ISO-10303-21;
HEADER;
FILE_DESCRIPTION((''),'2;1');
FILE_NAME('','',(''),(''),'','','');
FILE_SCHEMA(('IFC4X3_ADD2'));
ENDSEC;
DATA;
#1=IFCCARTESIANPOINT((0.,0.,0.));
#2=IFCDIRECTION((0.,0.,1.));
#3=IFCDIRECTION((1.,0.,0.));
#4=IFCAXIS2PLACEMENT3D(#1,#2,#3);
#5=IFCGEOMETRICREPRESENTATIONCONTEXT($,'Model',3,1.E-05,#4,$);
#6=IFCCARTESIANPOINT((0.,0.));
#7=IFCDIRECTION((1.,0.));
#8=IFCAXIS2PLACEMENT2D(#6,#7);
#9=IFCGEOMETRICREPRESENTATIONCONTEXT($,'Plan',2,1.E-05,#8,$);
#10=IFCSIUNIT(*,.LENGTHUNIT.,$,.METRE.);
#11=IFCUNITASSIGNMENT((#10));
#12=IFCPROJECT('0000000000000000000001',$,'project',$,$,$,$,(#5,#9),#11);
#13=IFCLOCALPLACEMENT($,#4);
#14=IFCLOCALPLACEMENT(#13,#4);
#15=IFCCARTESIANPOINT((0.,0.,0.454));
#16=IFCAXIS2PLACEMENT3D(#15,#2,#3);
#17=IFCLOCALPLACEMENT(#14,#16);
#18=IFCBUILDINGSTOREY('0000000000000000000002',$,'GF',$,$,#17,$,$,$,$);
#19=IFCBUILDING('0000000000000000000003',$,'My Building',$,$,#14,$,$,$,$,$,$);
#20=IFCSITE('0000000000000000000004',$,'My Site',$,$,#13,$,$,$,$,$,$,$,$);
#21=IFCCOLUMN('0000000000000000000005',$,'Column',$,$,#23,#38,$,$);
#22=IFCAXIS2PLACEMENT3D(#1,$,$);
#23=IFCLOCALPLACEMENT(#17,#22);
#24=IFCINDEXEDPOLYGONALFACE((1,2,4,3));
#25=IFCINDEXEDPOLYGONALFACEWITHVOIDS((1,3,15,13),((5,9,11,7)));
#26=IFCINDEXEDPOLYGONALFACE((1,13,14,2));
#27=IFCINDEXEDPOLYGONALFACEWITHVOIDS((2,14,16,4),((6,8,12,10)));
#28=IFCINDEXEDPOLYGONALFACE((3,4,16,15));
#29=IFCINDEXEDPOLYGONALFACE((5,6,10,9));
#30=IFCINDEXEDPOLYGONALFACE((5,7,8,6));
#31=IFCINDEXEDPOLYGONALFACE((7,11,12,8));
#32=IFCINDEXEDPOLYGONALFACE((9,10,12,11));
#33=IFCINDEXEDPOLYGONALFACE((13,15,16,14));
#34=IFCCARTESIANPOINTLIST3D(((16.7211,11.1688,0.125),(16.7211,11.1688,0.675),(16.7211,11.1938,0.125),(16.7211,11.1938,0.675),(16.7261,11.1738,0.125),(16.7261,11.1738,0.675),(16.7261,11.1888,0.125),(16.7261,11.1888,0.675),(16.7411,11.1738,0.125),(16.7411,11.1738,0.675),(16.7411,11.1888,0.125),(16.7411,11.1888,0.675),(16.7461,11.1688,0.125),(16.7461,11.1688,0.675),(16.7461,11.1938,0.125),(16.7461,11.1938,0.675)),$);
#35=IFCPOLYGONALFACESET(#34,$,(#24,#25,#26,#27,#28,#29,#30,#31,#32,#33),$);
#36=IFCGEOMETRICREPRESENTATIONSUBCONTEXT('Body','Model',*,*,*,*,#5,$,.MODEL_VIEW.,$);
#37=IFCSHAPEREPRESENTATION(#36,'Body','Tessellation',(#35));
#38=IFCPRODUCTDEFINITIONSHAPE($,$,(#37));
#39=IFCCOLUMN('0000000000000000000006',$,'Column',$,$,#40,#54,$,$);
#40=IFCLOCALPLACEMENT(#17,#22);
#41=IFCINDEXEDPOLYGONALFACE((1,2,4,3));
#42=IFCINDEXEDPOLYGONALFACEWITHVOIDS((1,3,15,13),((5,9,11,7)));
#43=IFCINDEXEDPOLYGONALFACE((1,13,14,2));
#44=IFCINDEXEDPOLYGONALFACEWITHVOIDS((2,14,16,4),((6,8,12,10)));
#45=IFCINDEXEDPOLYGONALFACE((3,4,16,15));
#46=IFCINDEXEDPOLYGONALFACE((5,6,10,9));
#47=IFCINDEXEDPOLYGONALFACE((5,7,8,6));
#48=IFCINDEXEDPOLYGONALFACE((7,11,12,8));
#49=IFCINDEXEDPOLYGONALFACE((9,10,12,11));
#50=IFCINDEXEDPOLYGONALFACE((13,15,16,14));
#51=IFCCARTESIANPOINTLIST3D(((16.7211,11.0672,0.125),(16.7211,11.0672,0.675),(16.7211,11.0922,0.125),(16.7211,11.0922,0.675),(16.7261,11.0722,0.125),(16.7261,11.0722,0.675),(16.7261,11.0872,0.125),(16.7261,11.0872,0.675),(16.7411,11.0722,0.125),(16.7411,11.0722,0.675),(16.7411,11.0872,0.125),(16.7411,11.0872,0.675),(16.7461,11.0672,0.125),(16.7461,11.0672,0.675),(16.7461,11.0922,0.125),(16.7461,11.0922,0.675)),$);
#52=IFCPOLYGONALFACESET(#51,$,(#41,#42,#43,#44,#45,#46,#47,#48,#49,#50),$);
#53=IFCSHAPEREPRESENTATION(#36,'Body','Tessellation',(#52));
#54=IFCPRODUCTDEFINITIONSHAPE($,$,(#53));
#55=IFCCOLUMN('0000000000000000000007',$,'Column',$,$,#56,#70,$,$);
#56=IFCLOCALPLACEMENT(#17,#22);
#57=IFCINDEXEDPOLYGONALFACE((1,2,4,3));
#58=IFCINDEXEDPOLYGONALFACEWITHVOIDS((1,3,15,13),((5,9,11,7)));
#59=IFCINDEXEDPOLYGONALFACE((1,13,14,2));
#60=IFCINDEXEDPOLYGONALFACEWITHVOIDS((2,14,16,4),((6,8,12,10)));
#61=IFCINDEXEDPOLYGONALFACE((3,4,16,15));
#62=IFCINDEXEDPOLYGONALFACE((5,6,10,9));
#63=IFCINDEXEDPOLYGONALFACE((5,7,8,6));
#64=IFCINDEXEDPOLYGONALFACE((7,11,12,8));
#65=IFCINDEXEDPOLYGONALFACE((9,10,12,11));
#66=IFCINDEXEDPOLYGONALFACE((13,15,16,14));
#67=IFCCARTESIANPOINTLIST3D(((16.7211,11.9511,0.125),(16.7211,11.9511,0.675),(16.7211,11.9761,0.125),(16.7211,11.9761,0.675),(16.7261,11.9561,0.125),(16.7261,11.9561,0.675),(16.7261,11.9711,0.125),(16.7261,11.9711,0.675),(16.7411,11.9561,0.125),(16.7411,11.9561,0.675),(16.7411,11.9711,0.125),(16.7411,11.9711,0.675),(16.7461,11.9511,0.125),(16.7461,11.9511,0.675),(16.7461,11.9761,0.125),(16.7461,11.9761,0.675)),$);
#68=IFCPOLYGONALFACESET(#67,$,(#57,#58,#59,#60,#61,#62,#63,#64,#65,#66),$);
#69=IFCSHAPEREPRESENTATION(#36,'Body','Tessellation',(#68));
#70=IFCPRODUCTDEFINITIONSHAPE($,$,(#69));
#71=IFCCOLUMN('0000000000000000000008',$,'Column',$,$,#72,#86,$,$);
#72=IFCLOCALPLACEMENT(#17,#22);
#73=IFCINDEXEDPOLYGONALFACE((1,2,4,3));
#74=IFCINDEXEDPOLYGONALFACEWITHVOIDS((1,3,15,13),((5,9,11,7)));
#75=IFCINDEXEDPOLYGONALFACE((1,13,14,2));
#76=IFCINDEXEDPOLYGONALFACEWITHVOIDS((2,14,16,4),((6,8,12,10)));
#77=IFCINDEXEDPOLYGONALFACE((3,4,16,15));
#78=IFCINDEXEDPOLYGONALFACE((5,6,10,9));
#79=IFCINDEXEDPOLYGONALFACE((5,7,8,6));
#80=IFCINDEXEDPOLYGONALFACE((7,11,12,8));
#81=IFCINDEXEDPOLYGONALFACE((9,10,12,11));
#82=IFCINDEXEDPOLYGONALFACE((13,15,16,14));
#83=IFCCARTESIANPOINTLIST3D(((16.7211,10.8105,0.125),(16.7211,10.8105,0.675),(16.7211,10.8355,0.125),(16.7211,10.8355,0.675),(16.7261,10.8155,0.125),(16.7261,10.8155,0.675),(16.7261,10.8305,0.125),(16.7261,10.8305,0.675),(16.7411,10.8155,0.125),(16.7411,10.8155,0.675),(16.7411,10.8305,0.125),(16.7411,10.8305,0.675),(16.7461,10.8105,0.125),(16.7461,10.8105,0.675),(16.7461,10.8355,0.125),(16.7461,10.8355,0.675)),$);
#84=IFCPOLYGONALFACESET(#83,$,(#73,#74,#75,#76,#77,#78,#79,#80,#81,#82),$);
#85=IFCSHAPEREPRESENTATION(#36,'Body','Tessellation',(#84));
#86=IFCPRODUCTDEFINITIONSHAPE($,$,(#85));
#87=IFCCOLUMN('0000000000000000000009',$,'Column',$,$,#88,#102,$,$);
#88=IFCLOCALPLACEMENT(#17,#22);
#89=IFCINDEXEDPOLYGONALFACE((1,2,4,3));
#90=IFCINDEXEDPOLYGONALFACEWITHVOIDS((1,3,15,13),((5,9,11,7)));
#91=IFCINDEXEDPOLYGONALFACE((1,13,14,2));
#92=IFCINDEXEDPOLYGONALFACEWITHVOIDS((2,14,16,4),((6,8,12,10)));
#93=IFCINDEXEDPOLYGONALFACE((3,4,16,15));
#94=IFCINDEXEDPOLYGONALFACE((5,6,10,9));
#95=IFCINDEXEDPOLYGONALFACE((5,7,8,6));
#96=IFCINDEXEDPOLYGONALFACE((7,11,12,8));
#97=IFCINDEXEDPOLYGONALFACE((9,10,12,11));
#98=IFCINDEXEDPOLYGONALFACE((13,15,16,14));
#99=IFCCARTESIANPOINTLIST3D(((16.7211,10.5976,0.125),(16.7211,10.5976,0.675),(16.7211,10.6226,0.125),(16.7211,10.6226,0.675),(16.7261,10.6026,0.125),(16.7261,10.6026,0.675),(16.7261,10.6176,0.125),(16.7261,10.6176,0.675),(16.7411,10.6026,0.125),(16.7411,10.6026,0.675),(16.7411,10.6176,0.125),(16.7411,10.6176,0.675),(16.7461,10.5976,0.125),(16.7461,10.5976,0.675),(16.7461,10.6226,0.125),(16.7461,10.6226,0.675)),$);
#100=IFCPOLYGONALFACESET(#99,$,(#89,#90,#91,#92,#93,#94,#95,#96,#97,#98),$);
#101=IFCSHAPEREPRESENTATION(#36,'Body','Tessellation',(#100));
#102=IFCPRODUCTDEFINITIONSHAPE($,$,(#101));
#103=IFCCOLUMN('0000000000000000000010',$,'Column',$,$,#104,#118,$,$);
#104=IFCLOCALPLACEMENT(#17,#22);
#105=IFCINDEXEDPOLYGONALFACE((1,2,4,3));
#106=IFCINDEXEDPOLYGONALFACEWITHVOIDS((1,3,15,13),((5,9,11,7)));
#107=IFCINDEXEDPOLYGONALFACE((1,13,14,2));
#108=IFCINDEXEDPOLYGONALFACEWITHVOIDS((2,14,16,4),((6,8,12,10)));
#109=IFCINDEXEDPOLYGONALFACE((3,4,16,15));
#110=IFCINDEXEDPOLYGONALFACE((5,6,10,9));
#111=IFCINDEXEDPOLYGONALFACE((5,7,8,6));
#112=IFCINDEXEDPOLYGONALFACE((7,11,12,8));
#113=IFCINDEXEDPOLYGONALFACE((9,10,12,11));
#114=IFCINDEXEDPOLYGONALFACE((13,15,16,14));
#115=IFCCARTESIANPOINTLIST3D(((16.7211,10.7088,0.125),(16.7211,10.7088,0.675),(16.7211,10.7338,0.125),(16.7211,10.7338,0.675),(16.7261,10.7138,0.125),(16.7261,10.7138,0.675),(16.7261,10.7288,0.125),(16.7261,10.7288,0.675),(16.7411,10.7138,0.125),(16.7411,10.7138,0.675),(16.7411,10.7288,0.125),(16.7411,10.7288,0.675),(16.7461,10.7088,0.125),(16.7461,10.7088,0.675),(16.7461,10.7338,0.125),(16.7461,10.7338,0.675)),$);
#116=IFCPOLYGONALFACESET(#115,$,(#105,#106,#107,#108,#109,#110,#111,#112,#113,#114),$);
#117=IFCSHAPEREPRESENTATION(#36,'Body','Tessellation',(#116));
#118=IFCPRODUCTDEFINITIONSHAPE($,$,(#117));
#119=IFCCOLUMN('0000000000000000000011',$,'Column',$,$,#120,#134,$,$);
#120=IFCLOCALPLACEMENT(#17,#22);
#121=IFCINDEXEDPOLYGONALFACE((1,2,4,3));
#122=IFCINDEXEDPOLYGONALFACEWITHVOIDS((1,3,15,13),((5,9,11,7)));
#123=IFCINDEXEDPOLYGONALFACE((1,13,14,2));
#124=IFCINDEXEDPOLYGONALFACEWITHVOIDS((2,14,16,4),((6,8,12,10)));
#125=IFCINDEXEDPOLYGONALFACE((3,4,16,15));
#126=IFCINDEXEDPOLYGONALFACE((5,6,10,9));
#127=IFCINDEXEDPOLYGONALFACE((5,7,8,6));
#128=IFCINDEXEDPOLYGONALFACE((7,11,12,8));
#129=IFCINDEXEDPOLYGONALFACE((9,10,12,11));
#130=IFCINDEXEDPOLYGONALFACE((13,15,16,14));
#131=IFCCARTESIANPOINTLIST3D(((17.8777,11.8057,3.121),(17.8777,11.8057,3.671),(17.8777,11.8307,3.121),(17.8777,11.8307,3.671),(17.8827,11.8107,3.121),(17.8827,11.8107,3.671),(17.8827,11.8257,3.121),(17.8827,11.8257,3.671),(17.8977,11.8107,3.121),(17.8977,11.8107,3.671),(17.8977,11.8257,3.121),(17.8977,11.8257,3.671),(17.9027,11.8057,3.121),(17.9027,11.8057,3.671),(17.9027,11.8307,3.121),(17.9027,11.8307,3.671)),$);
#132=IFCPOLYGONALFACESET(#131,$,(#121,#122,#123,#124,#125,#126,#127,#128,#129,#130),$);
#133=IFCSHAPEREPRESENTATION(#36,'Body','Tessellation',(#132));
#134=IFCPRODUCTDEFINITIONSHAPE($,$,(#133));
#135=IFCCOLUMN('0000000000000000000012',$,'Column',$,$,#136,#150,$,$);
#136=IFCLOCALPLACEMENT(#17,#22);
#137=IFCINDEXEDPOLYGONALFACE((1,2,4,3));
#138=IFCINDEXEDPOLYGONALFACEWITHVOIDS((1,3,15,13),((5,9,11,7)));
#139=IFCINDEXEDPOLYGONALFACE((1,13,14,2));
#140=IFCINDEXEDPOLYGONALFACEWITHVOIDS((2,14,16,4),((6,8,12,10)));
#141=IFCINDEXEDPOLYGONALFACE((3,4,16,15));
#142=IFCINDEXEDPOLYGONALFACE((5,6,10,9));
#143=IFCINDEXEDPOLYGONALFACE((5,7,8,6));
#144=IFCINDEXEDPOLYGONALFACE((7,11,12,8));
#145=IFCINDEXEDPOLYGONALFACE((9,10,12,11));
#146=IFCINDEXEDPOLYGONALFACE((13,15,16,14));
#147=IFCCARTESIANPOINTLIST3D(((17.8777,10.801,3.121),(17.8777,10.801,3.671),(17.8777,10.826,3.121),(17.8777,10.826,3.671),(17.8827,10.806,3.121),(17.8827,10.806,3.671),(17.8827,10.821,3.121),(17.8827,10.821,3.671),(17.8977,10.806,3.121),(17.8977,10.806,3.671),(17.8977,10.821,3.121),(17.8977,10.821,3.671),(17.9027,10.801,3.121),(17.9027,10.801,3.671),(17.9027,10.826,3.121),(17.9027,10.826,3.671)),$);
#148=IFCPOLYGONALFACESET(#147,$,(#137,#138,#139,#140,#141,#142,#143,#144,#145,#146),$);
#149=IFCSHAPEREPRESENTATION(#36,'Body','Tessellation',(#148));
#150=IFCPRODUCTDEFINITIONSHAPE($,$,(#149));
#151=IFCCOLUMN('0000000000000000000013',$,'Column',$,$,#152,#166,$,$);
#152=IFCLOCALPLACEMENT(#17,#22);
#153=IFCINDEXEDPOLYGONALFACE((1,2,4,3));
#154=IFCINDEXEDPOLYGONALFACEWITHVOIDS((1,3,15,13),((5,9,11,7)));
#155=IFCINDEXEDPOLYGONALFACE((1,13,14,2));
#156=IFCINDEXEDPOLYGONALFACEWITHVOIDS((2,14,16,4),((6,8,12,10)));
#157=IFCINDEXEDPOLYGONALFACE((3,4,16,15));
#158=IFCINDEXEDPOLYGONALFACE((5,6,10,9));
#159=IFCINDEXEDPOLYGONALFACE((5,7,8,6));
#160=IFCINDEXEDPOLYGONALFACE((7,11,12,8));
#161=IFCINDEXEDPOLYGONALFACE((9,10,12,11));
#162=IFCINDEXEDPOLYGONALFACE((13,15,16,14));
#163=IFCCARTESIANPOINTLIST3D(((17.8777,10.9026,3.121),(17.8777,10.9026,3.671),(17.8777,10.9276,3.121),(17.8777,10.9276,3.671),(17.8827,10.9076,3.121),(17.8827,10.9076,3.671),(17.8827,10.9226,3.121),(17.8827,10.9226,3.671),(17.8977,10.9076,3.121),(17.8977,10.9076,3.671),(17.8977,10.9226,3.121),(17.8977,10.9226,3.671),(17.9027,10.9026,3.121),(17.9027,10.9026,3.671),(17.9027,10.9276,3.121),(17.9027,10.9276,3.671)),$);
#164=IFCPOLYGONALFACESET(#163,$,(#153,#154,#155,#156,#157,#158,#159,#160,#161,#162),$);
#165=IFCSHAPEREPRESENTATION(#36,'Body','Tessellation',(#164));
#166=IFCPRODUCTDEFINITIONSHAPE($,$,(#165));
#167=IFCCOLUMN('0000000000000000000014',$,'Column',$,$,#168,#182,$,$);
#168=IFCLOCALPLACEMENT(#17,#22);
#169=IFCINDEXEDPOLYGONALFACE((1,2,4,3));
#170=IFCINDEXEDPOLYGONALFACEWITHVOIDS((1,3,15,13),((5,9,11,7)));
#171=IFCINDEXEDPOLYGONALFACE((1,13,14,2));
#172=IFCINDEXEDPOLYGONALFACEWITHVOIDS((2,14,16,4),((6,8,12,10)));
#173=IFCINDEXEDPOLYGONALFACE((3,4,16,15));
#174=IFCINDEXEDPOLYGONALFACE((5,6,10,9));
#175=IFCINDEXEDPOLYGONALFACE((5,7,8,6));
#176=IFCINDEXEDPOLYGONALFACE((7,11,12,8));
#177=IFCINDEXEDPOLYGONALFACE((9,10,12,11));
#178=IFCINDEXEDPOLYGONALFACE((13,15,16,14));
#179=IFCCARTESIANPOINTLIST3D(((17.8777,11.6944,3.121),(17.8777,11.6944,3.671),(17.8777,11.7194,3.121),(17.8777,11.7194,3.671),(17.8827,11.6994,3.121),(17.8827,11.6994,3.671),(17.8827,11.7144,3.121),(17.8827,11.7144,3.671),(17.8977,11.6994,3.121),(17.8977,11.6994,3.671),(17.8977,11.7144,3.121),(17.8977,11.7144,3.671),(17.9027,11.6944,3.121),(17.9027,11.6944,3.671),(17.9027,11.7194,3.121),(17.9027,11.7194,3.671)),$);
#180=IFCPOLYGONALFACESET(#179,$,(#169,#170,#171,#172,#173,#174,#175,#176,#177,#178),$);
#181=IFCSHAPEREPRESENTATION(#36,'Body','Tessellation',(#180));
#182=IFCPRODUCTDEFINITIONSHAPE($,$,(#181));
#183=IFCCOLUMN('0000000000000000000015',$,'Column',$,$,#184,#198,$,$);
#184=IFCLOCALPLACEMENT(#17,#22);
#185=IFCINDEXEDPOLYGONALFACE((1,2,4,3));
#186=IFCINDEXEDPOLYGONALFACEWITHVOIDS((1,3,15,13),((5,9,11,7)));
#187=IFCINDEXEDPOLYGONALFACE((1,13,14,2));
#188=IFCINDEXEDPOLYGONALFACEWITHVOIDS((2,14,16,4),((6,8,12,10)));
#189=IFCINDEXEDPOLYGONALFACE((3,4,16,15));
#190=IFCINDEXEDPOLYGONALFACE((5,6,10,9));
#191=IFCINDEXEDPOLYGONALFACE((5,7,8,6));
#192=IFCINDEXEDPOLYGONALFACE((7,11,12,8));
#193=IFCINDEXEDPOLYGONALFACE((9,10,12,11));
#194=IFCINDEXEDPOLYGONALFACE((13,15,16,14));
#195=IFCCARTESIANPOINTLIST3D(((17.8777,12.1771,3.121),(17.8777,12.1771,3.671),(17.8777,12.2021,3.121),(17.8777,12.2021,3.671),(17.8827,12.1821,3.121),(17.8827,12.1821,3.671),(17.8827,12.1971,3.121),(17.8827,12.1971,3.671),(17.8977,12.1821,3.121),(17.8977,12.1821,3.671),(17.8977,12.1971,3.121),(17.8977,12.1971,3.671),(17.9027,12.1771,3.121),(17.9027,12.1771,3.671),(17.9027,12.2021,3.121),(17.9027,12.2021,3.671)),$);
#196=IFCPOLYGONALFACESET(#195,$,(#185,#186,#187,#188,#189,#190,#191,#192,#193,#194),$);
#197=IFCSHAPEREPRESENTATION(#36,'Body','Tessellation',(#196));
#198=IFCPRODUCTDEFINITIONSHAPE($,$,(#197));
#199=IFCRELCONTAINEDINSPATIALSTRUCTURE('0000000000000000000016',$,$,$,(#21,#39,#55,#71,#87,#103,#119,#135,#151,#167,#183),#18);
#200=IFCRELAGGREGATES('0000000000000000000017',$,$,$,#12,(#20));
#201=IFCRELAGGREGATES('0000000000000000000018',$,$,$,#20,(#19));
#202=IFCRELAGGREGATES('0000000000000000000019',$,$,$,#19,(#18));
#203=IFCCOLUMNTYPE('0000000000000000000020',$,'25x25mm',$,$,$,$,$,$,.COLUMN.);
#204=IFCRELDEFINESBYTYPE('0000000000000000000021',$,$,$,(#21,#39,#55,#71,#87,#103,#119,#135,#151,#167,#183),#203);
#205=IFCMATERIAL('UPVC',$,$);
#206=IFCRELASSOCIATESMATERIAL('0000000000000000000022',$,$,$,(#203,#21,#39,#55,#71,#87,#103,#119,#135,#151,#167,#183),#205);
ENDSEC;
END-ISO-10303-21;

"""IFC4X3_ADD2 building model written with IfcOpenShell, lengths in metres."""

from ifc_helpers import new_model, si_unit, frame, origin_with_axes, origin_2d_with_axis, place, context, subcontext, project, spatial, hollow_rectangle, extrude, material, material_profile, profile_set, profile_usage, type_object, element, save


model = new_model("IFC4X3_ADD2")

# Units and contexts
model_context = context("Model", 3, precision=1e-05, world=origin_with_axes())
plan_context = context("Plan", 2, precision=1e-05, world=origin_2d_with_axis())
body_context = subcontext(model_context, "Body", "Model", "MODEL_VIEW")
ifc_project = project(units=[si_unit("LENGTHUNIT", "METRE")], contexts=[model_context, plan_context])

# Site, building, storey
site_placement = place(None, origin_with_axes())
site = spatial("IfcSite", under=ifc_project, at=site_placement, Name="My Site")
building_placement = place(site_placement, origin_with_axes())
building = spatial("IfcBuilding", under=site, at=building_placement, Name="My Building")
storey_placement = place(building_placement, frame((0.0, 0.0, 0.454), z_axis=(0.0, 0.0, 1.0), x_axis=(1.0, 0.0, 0.0)))
storey = spatial("IfcBuildingStorey", under=building, at=storey_placement, Name="GF")

# Columns
ifc_material_1 = material(Name="UPVC")
ifc_material_profile_1 = material_profile(ifc_material_1, hollow_rectangle(XDim=0.025, YDim=0.025, WallThickness=0.005))
ifc_profile_set_1 = profile_set([ifc_material_profile_1])
ifc_profile_usage_1 = profile_usage(ifc_profile_set_1)
column_type_1 = type_object("IfcColumnType", Name="25x25mm", PredefinedType="COLUMN", material=ifc_profile_set_1)
column_1_placement = place(storey_placement, frame((16.7336, 11.1813, 0.125), z_axis=(0.0, 0.0, 1.0), x_axis=(0.0, -1.0, 0.0)))
element("IfcColumn", 1, at=column_1_placement, inside=storey, type_object=column_type_1, material=ifc_profile_usage_1, Name="Column", context=body_context, shape_type="SweptSolid", body=[
    extrude(hollow_rectangle(XDim=0.025, YDim=0.025, WallThickness=0.005), origin_with_axes(), (0.0, 0.0, 1.0), 0.55),
])
ifc_profile_usage_2 = profile_usage(ifc_profile_set_1)
column_2_placement = place(storey_placement, frame((16.7336, 11.0797, 0.125), z_axis=(0.0, 0.0, 1.0), x_axis=(0.0, -1.0, 0.0)))
element("IfcColumn", 2, at=column_2_placement, inside=storey, type_object=column_type_1, material=ifc_profile_usage_2, Name="Column", context=body_context, shape_type="SweptSolid", body=[
    extrude(hollow_rectangle(XDim=0.025, YDim=0.025, WallThickness=0.005), origin_with_axes(), (0.0, 0.0, 1.0), 0.55),
])
ifc_profile_usage_3 = profile_usage(ifc_profile_set_1)
column_3_placement = place(storey_placement, frame((16.7336, 11.9636, 0.125), z_axis=(0.0, 0.0, 1.0), x_axis=(0.0, -1.0, 0.0)))
element("IfcColumn", 3, at=column_3_placement, inside=storey, type_object=column_type_1, material=ifc_profile_usage_3, Name="Column", context=body_context, shape_type="SweptSolid", body=[
    extrude(hollow_rectangle(XDim=0.025, YDim=0.025, WallThickness=0.005), origin_with_axes(), (0.0, 0.0, 1.0), 0.55),
])
ifc_profile_usage_4 = profile_usage(ifc_profile_set_1)
column_4_placement = place(storey_placement, frame((16.7336, 10.823, 0.125), z_axis=(0.0, 0.0, 1.0), x_axis=(0.0, -1.0, 0.0)))
element("IfcColumn", 4, at=column_4_placement, inside=storey, type_object=column_type_1, material=ifc_profile_usage_4, Name="Column", context=body_context, shape_type="SweptSolid", body=[
    extrude(hollow_rectangle(XDim=0.025, YDim=0.025, WallThickness=0.005), origin_with_axes(), (0.0, 0.0, 1.0), 0.55),
])
ifc_profile_usage_5 = profile_usage(ifc_profile_set_1)
column_5_placement = place(storey_placement, frame((16.7336, 10.6101, 0.125), z_axis=(0.0, 0.0, 1.0), x_axis=(0.0, -1.0, 0.0)))
element("IfcColumn", 5, at=column_5_placement, inside=storey, type_object=column_type_1, material=ifc_profile_usage_5, Name="Column", context=body_context, shape_type="SweptSolid", body=[
    extrude(hollow_rectangle(XDim=0.025, YDim=0.025, WallThickness=0.005), origin_with_axes(), (0.0, 0.0, 1.0), 0.55),
])
ifc_profile_usage_6 = profile_usage(ifc_profile_set_1)
column_6_placement = place(storey_placement, frame((16.7336, 10.7213, 0.125), z_axis=(0.0, 0.0, 1.0), x_axis=(0.0, -1.0, 0.0)))
element("IfcColumn", 6, at=column_6_placement, inside=storey, type_object=column_type_1, material=ifc_profile_usage_6, Name="Column", context=body_context, shape_type="SweptSolid", body=[
    extrude(hollow_rectangle(XDim=0.025, YDim=0.025, WallThickness=0.005), origin_with_axes(), (0.0, 0.0, 1.0), 0.55),
])
ifc_profile_usage_7 = profile_usage(ifc_profile_set_1)
column_7_placement = place(storey_placement, frame((17.8902, 11.8182, 3.121), z_axis=(0.0, 0.0, 1.0), x_axis=(0.0, -1.0, 0.0)))
element("IfcColumn", 7, at=column_7_placement, inside=storey, type_object=column_type_1, material=ifc_profile_usage_7, Name="Column", context=body_context, shape_type="SweptSolid", body=[
    extrude(hollow_rectangle(XDim=0.025, YDim=0.025, WallThickness=0.005), origin_with_axes(), (0.0, 0.0, 1.0), 0.55),
])
ifc_profile_usage_8 = profile_usage(ifc_profile_set_1)
column_8_placement = place(storey_placement, frame((17.8902, 10.8135, 3.121), z_axis=(0.0, 0.0, 1.0), x_axis=(0.0, -1.0, 0.0)))
element("IfcColumn", 8, at=column_8_placement, inside=storey, type_object=column_type_1, material=ifc_profile_usage_8, Name="Column", context=body_context, shape_type="SweptSolid", body=[
    extrude(hollow_rectangle(XDim=0.025, YDim=0.025, WallThickness=0.005), origin_with_axes(), (0.0, 0.0, 1.0), 0.55),
])
ifc_profile_usage_9 = profile_usage(ifc_profile_set_1)
column_9_placement = place(storey_placement, frame((17.8902, 10.9151, 3.121), z_axis=(0.0, 0.0, 1.0), x_axis=(0.0, -1.0, 0.0)))
element("IfcColumn", 9, at=column_9_placement, inside=storey, type_object=column_type_1, material=ifc_profile_usage_9, Name="Column", context=body_context, shape_type="SweptSolid", body=[
    extrude(hollow_rectangle(XDim=0.025, YDim=0.025, WallThickness=0.005), origin_with_axes(), (0.0, 0.0, 1.0), 0.55),
])
ifc_profile_usage_10 = profile_usage(ifc_profile_set_1)
column_10_placement = place(storey_placement, frame((17.8902, 11.7069, 3.121), z_axis=(0.0, 0.0, 1.0), x_axis=(0.0, -1.0, 0.0)))
element("IfcColumn", 10, at=column_10_placement, inside=storey, type_object=column_type_1, material=ifc_profile_usage_10, Name="Column", context=body_context, shape_type="SweptSolid", body=[
    extrude(hollow_rectangle(XDim=0.025, YDim=0.025, WallThickness=0.005), origin_with_axes(), (0.0, 0.0, 1.0), 0.55),
])
ifc_profile_usage_11 = profile_usage(ifc_profile_set_1)
column_11_placement = place(storey_placement, frame((17.8902, 12.1896, 3.121), z_axis=(0.0, 0.0, 1.0), x_axis=(0.0, -1.0, 0.0)))
element("IfcColumn", 11, at=column_11_placement, inside=storey, type_object=column_type_1, material=ifc_profile_usage_11, Name="Column", context=body_context, shape_type="SweptSolid", body=[
    extrude(hollow_rectangle(XDim=0.025, YDim=0.025, WallThickness=0.005), origin_with_axes(), (0.0, 0.0, 1.0), 0.55),
])

save(model, "model.ifc")
